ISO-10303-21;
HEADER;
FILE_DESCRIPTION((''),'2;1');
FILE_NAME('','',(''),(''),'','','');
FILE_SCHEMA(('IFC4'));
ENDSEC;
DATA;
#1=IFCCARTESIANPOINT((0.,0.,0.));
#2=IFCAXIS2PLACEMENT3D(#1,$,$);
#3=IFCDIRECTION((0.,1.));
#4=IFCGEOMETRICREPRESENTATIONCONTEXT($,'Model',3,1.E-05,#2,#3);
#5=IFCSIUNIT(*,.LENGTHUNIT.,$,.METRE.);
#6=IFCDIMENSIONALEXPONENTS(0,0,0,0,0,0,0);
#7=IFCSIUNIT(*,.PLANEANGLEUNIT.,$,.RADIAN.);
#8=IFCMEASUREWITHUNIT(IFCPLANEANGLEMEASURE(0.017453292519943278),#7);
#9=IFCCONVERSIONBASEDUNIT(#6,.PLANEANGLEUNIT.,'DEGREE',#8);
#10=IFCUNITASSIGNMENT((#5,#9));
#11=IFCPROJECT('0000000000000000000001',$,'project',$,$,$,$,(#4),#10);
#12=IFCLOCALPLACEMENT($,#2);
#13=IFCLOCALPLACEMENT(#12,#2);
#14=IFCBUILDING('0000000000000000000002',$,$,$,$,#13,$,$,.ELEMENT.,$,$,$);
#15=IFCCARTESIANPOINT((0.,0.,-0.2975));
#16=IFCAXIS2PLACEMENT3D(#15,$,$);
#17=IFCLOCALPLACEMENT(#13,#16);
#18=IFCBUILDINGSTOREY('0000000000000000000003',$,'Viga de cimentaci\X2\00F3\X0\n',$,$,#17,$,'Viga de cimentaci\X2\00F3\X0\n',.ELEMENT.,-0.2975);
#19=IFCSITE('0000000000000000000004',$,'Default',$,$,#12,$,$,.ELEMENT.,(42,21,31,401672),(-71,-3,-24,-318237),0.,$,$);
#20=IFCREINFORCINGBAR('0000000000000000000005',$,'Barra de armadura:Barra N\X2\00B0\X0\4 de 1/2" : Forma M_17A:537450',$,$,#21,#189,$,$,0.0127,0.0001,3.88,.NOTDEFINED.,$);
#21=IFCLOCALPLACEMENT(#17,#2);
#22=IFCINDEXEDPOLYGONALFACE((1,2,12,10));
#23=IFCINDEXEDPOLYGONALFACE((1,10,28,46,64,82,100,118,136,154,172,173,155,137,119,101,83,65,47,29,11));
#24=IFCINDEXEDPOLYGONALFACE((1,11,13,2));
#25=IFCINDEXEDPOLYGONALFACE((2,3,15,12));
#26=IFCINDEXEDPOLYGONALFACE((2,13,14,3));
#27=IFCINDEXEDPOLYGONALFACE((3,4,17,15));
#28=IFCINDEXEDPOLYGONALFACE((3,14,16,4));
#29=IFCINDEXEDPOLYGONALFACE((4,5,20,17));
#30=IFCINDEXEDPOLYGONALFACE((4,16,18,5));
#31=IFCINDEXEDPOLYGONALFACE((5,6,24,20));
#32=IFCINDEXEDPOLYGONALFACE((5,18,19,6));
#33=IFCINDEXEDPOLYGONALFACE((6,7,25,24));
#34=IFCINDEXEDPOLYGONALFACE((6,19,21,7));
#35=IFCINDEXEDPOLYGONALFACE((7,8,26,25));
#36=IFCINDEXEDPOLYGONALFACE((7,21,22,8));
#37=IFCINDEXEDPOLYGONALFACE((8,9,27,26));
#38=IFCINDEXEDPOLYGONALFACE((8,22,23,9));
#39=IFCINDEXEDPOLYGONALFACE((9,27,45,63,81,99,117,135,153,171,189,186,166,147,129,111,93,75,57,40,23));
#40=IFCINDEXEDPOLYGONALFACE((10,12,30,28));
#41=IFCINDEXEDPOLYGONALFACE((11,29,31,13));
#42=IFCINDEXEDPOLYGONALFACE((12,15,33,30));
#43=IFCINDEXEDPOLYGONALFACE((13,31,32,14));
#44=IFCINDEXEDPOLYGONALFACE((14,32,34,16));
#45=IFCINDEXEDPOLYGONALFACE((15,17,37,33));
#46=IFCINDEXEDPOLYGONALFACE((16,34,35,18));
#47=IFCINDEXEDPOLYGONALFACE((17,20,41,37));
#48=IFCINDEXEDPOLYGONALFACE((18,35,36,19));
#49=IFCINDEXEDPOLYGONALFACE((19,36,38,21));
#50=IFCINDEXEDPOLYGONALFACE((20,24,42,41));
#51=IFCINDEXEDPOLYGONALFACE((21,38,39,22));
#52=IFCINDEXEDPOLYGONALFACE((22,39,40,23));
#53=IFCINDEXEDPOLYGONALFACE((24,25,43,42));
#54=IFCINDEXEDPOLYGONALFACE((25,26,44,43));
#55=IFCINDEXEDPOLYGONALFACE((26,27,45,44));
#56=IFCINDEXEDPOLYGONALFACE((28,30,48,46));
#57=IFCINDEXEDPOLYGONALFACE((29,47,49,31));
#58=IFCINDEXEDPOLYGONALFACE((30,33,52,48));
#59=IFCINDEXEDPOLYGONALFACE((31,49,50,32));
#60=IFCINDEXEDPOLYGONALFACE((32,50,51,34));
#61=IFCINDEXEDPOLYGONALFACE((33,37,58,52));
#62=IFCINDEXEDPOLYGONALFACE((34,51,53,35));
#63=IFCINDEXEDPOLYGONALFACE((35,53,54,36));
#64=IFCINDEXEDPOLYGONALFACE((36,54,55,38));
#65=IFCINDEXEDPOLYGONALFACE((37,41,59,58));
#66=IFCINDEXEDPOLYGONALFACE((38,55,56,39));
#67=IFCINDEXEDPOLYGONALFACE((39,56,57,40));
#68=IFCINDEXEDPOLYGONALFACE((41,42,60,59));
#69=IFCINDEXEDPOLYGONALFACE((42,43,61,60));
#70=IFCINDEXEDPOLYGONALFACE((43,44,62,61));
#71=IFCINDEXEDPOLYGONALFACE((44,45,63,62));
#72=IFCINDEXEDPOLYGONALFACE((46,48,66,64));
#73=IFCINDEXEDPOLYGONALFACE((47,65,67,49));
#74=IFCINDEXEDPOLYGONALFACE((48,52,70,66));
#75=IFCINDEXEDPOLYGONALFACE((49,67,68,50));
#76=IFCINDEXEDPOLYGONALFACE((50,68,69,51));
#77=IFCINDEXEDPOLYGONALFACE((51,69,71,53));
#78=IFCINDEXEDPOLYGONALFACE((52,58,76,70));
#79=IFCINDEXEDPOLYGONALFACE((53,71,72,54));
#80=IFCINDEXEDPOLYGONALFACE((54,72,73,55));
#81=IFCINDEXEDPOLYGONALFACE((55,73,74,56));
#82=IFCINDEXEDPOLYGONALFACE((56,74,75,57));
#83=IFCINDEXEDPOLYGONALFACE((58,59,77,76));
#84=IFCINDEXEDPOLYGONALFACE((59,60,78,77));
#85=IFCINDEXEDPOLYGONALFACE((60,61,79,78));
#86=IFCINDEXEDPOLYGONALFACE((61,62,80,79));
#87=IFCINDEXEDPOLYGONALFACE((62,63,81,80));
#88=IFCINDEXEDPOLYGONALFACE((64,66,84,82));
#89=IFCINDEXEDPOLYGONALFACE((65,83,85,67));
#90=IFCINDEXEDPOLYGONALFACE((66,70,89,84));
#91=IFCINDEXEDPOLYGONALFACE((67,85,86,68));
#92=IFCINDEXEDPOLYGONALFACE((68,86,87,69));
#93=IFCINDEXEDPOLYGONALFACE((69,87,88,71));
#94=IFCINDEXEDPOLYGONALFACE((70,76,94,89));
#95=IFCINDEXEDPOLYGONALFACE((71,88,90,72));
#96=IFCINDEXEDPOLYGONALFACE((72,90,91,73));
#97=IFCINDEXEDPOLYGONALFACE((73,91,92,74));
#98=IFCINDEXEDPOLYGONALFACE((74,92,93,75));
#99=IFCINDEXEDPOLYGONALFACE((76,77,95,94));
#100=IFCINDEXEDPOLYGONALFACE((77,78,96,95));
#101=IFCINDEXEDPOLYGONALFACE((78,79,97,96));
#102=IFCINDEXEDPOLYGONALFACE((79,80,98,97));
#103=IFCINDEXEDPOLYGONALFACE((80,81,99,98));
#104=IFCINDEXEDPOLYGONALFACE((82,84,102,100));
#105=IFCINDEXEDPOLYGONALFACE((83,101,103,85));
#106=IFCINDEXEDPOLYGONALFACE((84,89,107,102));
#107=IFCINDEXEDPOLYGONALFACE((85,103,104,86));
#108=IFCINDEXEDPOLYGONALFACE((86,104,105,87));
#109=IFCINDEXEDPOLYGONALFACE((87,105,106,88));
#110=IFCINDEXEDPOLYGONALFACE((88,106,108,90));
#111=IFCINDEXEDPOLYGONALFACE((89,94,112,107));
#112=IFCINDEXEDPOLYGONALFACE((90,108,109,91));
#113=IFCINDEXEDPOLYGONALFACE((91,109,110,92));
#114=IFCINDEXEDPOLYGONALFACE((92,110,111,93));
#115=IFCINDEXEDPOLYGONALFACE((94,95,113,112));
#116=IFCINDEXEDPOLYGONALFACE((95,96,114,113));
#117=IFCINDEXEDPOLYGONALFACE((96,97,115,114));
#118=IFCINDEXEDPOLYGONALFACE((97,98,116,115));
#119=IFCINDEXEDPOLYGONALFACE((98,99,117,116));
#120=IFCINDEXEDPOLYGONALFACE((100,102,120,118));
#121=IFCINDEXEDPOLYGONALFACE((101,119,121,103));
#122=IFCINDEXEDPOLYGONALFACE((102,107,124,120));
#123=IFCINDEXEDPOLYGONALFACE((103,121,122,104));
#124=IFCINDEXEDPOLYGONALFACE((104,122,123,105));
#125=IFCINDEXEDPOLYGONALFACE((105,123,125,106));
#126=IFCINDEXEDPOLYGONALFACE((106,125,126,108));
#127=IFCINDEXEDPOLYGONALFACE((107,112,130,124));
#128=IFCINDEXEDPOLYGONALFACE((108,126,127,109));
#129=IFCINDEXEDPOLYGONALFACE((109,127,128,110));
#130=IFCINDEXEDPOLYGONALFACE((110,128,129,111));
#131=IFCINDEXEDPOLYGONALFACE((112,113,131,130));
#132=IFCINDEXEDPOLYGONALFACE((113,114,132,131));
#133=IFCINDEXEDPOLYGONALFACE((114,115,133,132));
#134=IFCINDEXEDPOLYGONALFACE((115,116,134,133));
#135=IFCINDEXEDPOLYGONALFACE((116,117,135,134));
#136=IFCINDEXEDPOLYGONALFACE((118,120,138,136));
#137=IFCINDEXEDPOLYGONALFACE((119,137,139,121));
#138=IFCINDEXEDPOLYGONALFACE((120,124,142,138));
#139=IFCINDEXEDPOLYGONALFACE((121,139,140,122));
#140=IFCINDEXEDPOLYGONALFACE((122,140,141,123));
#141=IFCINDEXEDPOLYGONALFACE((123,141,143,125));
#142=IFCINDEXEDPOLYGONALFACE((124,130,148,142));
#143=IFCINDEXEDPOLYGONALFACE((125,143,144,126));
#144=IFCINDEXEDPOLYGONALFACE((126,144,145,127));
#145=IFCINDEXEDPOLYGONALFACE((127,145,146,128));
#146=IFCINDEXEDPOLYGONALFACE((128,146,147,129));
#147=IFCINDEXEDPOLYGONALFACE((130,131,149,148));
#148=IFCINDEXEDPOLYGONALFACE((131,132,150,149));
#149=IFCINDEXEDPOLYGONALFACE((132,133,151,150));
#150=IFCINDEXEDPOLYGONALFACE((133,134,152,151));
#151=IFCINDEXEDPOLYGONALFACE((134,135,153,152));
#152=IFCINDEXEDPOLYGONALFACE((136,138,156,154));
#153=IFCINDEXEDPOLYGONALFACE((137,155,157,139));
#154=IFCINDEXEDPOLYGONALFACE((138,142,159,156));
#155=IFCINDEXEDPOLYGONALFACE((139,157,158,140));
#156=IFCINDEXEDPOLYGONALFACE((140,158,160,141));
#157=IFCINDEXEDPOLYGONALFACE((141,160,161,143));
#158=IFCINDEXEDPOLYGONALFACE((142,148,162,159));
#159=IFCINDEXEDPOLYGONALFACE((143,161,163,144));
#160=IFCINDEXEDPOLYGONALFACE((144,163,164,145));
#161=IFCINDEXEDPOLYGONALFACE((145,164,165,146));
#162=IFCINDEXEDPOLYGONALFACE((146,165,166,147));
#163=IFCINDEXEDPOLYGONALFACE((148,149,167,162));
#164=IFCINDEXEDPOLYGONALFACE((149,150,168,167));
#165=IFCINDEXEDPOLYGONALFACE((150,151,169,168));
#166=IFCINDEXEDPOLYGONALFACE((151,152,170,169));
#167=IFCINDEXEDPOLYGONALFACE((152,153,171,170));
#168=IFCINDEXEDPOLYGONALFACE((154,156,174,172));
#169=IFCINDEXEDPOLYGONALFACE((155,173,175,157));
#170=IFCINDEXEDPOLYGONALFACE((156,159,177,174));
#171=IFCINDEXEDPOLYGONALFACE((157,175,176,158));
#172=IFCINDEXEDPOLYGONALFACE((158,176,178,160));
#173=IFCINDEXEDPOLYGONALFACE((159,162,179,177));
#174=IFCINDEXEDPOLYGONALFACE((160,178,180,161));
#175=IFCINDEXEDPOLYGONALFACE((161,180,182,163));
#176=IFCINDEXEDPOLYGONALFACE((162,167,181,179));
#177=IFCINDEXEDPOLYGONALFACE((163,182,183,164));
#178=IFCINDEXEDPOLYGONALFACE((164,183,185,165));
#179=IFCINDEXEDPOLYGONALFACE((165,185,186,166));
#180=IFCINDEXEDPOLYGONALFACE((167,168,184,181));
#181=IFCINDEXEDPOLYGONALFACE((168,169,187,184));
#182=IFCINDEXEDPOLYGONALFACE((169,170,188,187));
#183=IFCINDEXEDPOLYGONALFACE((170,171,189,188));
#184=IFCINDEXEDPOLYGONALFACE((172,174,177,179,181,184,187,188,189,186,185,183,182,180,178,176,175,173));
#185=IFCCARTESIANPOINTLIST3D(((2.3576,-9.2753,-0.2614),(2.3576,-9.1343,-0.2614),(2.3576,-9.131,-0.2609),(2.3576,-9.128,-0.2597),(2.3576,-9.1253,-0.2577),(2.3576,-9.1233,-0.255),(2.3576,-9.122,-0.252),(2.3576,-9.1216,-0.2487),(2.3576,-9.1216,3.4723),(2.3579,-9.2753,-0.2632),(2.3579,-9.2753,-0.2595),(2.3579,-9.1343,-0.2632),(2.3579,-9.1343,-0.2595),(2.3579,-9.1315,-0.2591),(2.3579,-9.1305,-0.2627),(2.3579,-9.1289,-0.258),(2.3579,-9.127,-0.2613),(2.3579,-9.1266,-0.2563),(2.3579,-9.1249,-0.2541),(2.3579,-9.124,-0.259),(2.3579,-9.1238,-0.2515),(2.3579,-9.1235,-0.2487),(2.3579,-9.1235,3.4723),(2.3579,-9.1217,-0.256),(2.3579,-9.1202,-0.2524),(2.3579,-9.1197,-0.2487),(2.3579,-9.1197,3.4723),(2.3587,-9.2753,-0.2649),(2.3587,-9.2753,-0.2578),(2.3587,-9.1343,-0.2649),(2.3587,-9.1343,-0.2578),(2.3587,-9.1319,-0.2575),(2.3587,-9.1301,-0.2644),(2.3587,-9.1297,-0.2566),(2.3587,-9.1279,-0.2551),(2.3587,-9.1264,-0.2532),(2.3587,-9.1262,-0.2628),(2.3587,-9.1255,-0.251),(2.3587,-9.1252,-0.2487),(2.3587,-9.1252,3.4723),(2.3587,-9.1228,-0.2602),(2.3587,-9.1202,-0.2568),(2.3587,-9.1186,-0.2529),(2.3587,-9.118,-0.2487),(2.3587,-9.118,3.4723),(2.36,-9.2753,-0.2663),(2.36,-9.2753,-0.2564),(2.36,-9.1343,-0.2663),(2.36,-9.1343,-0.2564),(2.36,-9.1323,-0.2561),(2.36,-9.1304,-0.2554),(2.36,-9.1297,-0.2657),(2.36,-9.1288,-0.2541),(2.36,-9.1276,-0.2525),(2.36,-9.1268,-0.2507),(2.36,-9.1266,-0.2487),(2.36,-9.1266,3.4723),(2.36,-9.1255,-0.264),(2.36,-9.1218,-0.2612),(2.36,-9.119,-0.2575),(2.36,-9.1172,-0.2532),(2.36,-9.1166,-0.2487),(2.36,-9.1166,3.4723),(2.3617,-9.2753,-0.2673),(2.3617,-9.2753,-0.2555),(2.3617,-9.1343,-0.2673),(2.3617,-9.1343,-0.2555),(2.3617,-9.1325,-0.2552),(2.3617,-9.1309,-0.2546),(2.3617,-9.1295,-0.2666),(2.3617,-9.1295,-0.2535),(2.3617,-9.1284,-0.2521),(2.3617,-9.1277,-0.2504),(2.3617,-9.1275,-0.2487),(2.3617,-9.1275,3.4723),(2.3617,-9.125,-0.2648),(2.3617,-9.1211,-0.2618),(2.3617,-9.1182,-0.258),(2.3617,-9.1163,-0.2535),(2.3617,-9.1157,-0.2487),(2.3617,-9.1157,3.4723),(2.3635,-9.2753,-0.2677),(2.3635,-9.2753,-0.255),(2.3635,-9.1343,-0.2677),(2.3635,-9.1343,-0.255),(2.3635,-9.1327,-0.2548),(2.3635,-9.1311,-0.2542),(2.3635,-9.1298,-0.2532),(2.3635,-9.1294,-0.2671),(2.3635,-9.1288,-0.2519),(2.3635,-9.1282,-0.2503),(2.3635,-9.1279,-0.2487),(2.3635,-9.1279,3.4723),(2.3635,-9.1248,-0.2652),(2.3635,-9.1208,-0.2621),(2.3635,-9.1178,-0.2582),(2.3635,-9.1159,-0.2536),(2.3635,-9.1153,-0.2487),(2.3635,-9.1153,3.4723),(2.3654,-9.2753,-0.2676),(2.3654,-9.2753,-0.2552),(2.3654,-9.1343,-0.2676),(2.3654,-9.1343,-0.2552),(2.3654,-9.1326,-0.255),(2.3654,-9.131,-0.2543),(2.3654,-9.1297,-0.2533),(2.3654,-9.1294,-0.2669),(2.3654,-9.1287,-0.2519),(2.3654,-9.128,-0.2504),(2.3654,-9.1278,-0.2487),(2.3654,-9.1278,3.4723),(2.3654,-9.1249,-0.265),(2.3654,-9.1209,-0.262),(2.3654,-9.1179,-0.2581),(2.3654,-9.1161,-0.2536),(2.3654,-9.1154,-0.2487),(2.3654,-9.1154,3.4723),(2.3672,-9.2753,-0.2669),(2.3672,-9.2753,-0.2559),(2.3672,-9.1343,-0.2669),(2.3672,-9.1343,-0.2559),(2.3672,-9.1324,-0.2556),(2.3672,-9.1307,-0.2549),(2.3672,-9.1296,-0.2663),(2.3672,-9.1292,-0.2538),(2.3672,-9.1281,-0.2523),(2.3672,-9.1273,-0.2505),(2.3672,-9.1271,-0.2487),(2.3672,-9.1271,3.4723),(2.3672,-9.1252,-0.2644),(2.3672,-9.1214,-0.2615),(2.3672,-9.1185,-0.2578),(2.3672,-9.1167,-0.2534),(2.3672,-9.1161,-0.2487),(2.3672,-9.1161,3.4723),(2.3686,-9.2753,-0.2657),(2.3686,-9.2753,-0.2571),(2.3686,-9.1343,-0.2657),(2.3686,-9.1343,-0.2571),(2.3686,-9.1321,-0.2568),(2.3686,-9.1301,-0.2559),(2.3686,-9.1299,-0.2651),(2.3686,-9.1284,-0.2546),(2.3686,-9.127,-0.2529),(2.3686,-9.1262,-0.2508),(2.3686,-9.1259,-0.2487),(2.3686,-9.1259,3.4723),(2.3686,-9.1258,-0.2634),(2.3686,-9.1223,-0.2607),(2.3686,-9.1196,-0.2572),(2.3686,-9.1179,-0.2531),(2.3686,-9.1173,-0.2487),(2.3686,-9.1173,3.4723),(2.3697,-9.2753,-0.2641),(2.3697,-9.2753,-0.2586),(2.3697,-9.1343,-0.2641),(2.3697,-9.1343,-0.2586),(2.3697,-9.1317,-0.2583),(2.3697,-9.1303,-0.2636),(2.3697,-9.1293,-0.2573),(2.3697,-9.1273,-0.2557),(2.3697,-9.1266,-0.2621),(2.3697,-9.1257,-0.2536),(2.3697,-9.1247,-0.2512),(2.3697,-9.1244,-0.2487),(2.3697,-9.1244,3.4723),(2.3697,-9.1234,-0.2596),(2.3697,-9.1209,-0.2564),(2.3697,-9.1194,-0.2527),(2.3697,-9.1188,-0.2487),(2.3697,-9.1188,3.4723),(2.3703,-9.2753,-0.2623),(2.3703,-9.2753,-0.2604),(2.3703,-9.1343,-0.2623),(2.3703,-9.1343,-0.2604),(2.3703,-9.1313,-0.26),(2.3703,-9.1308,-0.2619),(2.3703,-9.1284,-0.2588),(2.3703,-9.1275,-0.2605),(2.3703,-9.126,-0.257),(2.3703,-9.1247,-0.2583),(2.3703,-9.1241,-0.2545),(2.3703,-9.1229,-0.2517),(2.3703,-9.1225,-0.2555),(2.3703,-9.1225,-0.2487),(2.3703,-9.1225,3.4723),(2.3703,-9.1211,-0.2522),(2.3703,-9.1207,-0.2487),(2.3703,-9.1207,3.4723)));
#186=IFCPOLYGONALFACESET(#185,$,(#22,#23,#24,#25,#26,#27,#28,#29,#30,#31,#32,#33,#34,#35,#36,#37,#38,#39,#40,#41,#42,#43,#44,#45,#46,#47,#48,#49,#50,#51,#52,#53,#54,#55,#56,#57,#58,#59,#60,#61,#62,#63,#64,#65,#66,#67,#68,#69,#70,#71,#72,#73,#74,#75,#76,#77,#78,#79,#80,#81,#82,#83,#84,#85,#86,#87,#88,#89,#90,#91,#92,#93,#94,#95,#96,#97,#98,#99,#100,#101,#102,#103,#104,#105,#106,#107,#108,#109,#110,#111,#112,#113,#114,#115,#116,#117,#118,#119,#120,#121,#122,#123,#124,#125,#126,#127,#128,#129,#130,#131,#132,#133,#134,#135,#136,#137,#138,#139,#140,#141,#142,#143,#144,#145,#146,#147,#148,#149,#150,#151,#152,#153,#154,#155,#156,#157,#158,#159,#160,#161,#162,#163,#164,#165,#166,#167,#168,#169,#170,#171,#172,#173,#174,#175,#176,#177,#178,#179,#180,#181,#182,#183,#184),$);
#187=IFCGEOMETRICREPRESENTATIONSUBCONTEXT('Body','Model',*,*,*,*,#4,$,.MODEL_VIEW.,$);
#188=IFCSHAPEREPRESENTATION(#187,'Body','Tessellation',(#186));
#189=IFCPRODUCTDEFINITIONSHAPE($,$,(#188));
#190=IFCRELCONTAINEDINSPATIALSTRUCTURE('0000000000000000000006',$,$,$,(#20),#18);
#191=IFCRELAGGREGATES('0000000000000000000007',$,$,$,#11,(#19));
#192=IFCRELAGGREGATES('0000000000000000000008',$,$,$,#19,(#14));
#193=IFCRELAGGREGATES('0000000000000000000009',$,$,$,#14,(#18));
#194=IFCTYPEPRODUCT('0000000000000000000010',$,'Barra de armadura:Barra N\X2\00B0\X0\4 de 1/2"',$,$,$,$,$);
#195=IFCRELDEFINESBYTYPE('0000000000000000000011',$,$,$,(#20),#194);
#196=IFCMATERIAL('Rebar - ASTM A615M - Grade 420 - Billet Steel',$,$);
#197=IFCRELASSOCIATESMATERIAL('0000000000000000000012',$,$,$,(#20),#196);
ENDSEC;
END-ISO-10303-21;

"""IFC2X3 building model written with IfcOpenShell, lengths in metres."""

from ifc_helpers import new_model, entity, si_unit, converted_unit, direction, frame, origin, place, context, subcontext, project, spatial, material, type_object, element, save


model = new_model("IFC2X3")

# Units and contexts
model_context = context("Model", 3, precision=1e-05, world=origin(), true_north=direction((0.0, 1.0)))
body_context = subcontext(model_context, "Body", "Model", "MODEL_VIEW")
ifc_project = project(units=[si_unit("LENGTHUNIT", "METRE"), converted_unit("PLANEANGLEUNIT", "DEGREE", entity("IfcPlaneAngleMeasure", 0.017453292519943278), si_unit("PLANEANGLEUNIT", "RADIAN"), dimensions=[0, 0, 0, 0, 0, 0, 0])], contexts=[model_context])

# Site, building, storey
site_placement = place(None, origin())
site = spatial("IfcSite", under=ifc_project, at=site_placement, Name="Default", CompositionType="ELEMENT", RefLatitude=(42, 21, 31, 401672), RefLongitude=(-71, -3, -24, -318237), RefElevation=0.0)
building_placement = place(site_placement, origin())
building = spatial("IfcBuilding", under=site, at=building_placement, CompositionType="ELEMENT")
storey_placement = place(building_placement, frame((0.0, 0.0, -0.2975)))
storey = spatial("IfcBuildingStorey", under=building, at=storey_placement, Name="Viga de cimentación", LongName="Viga de cimentación", CompositionType="ELEMENT", Elevation=-0.2975)

# Reinforcing bar
ifc_material = material(Name="Rebar - ASTM A615M - Grade 420 - Billet Steel")
type_product_1 = type_object("IfcTypeProduct", Name="Barra de armadura:Barra N°4 de 1/2\"")
reinforcing_bar_1_placement = place(storey_placement, origin())
element("IfcReinforcingBar", 1, at=reinforcing_bar_1_placement, inside=storey, type_object=type_product_1, material=ifc_material, Name="Barra de armadura:Barra N°4 de 1/2\" : Forma M_17A:537450", BarLength=3.88, BarRole="NOTDEFINED", CrossSectionArea=0.0001, NominalDiameter=0.0127, context=body_context, shape_type="AdvancedSweptSolid", body=[
    entity("IfcSweptDiskSolid", entity("IfcCompositeCurve", [entity("IfcCompositeCurveSegment", "CONTINUOUS", True, entity("IfcPolyline", [entity("IfcCartesianPoint", [2.364, -9.1216, 3.4723]), entity("IfcCartesianPoint", [2.364, -9.1216, -0.2487])])), entity("IfcCompositeCurveSegment", "CONTINUOUS", True, entity("IfcTrimmedCurve", entity("IfcCircle", entity("IfcAxis2Placement3D", entity("IfcCartesianPoint", [2.364, -9.1343, -0.2487]), entity("IfcDirection", [-1.0, 0.0, 0.0]), entity("IfcDirection", [0.0, 0.0, -1.0])), 0.0127), [entity("IfcParameterValue", 270.0)], [entity("IfcParameterValue", 360.0)], True, "PARAMETER")), entity("IfcCompositeCurveSegment", "CONTINUOUS", True, entity("IfcPolyline", [entity("IfcCartesianPoint", [2.364, -9.1343, -0.2614]), entity("IfcCartesianPoint", [2.364, -9.2753, -0.2614])]))], False), 0.0063, None, 0.0, 92.0),
])

save(model, "model.ifc")
